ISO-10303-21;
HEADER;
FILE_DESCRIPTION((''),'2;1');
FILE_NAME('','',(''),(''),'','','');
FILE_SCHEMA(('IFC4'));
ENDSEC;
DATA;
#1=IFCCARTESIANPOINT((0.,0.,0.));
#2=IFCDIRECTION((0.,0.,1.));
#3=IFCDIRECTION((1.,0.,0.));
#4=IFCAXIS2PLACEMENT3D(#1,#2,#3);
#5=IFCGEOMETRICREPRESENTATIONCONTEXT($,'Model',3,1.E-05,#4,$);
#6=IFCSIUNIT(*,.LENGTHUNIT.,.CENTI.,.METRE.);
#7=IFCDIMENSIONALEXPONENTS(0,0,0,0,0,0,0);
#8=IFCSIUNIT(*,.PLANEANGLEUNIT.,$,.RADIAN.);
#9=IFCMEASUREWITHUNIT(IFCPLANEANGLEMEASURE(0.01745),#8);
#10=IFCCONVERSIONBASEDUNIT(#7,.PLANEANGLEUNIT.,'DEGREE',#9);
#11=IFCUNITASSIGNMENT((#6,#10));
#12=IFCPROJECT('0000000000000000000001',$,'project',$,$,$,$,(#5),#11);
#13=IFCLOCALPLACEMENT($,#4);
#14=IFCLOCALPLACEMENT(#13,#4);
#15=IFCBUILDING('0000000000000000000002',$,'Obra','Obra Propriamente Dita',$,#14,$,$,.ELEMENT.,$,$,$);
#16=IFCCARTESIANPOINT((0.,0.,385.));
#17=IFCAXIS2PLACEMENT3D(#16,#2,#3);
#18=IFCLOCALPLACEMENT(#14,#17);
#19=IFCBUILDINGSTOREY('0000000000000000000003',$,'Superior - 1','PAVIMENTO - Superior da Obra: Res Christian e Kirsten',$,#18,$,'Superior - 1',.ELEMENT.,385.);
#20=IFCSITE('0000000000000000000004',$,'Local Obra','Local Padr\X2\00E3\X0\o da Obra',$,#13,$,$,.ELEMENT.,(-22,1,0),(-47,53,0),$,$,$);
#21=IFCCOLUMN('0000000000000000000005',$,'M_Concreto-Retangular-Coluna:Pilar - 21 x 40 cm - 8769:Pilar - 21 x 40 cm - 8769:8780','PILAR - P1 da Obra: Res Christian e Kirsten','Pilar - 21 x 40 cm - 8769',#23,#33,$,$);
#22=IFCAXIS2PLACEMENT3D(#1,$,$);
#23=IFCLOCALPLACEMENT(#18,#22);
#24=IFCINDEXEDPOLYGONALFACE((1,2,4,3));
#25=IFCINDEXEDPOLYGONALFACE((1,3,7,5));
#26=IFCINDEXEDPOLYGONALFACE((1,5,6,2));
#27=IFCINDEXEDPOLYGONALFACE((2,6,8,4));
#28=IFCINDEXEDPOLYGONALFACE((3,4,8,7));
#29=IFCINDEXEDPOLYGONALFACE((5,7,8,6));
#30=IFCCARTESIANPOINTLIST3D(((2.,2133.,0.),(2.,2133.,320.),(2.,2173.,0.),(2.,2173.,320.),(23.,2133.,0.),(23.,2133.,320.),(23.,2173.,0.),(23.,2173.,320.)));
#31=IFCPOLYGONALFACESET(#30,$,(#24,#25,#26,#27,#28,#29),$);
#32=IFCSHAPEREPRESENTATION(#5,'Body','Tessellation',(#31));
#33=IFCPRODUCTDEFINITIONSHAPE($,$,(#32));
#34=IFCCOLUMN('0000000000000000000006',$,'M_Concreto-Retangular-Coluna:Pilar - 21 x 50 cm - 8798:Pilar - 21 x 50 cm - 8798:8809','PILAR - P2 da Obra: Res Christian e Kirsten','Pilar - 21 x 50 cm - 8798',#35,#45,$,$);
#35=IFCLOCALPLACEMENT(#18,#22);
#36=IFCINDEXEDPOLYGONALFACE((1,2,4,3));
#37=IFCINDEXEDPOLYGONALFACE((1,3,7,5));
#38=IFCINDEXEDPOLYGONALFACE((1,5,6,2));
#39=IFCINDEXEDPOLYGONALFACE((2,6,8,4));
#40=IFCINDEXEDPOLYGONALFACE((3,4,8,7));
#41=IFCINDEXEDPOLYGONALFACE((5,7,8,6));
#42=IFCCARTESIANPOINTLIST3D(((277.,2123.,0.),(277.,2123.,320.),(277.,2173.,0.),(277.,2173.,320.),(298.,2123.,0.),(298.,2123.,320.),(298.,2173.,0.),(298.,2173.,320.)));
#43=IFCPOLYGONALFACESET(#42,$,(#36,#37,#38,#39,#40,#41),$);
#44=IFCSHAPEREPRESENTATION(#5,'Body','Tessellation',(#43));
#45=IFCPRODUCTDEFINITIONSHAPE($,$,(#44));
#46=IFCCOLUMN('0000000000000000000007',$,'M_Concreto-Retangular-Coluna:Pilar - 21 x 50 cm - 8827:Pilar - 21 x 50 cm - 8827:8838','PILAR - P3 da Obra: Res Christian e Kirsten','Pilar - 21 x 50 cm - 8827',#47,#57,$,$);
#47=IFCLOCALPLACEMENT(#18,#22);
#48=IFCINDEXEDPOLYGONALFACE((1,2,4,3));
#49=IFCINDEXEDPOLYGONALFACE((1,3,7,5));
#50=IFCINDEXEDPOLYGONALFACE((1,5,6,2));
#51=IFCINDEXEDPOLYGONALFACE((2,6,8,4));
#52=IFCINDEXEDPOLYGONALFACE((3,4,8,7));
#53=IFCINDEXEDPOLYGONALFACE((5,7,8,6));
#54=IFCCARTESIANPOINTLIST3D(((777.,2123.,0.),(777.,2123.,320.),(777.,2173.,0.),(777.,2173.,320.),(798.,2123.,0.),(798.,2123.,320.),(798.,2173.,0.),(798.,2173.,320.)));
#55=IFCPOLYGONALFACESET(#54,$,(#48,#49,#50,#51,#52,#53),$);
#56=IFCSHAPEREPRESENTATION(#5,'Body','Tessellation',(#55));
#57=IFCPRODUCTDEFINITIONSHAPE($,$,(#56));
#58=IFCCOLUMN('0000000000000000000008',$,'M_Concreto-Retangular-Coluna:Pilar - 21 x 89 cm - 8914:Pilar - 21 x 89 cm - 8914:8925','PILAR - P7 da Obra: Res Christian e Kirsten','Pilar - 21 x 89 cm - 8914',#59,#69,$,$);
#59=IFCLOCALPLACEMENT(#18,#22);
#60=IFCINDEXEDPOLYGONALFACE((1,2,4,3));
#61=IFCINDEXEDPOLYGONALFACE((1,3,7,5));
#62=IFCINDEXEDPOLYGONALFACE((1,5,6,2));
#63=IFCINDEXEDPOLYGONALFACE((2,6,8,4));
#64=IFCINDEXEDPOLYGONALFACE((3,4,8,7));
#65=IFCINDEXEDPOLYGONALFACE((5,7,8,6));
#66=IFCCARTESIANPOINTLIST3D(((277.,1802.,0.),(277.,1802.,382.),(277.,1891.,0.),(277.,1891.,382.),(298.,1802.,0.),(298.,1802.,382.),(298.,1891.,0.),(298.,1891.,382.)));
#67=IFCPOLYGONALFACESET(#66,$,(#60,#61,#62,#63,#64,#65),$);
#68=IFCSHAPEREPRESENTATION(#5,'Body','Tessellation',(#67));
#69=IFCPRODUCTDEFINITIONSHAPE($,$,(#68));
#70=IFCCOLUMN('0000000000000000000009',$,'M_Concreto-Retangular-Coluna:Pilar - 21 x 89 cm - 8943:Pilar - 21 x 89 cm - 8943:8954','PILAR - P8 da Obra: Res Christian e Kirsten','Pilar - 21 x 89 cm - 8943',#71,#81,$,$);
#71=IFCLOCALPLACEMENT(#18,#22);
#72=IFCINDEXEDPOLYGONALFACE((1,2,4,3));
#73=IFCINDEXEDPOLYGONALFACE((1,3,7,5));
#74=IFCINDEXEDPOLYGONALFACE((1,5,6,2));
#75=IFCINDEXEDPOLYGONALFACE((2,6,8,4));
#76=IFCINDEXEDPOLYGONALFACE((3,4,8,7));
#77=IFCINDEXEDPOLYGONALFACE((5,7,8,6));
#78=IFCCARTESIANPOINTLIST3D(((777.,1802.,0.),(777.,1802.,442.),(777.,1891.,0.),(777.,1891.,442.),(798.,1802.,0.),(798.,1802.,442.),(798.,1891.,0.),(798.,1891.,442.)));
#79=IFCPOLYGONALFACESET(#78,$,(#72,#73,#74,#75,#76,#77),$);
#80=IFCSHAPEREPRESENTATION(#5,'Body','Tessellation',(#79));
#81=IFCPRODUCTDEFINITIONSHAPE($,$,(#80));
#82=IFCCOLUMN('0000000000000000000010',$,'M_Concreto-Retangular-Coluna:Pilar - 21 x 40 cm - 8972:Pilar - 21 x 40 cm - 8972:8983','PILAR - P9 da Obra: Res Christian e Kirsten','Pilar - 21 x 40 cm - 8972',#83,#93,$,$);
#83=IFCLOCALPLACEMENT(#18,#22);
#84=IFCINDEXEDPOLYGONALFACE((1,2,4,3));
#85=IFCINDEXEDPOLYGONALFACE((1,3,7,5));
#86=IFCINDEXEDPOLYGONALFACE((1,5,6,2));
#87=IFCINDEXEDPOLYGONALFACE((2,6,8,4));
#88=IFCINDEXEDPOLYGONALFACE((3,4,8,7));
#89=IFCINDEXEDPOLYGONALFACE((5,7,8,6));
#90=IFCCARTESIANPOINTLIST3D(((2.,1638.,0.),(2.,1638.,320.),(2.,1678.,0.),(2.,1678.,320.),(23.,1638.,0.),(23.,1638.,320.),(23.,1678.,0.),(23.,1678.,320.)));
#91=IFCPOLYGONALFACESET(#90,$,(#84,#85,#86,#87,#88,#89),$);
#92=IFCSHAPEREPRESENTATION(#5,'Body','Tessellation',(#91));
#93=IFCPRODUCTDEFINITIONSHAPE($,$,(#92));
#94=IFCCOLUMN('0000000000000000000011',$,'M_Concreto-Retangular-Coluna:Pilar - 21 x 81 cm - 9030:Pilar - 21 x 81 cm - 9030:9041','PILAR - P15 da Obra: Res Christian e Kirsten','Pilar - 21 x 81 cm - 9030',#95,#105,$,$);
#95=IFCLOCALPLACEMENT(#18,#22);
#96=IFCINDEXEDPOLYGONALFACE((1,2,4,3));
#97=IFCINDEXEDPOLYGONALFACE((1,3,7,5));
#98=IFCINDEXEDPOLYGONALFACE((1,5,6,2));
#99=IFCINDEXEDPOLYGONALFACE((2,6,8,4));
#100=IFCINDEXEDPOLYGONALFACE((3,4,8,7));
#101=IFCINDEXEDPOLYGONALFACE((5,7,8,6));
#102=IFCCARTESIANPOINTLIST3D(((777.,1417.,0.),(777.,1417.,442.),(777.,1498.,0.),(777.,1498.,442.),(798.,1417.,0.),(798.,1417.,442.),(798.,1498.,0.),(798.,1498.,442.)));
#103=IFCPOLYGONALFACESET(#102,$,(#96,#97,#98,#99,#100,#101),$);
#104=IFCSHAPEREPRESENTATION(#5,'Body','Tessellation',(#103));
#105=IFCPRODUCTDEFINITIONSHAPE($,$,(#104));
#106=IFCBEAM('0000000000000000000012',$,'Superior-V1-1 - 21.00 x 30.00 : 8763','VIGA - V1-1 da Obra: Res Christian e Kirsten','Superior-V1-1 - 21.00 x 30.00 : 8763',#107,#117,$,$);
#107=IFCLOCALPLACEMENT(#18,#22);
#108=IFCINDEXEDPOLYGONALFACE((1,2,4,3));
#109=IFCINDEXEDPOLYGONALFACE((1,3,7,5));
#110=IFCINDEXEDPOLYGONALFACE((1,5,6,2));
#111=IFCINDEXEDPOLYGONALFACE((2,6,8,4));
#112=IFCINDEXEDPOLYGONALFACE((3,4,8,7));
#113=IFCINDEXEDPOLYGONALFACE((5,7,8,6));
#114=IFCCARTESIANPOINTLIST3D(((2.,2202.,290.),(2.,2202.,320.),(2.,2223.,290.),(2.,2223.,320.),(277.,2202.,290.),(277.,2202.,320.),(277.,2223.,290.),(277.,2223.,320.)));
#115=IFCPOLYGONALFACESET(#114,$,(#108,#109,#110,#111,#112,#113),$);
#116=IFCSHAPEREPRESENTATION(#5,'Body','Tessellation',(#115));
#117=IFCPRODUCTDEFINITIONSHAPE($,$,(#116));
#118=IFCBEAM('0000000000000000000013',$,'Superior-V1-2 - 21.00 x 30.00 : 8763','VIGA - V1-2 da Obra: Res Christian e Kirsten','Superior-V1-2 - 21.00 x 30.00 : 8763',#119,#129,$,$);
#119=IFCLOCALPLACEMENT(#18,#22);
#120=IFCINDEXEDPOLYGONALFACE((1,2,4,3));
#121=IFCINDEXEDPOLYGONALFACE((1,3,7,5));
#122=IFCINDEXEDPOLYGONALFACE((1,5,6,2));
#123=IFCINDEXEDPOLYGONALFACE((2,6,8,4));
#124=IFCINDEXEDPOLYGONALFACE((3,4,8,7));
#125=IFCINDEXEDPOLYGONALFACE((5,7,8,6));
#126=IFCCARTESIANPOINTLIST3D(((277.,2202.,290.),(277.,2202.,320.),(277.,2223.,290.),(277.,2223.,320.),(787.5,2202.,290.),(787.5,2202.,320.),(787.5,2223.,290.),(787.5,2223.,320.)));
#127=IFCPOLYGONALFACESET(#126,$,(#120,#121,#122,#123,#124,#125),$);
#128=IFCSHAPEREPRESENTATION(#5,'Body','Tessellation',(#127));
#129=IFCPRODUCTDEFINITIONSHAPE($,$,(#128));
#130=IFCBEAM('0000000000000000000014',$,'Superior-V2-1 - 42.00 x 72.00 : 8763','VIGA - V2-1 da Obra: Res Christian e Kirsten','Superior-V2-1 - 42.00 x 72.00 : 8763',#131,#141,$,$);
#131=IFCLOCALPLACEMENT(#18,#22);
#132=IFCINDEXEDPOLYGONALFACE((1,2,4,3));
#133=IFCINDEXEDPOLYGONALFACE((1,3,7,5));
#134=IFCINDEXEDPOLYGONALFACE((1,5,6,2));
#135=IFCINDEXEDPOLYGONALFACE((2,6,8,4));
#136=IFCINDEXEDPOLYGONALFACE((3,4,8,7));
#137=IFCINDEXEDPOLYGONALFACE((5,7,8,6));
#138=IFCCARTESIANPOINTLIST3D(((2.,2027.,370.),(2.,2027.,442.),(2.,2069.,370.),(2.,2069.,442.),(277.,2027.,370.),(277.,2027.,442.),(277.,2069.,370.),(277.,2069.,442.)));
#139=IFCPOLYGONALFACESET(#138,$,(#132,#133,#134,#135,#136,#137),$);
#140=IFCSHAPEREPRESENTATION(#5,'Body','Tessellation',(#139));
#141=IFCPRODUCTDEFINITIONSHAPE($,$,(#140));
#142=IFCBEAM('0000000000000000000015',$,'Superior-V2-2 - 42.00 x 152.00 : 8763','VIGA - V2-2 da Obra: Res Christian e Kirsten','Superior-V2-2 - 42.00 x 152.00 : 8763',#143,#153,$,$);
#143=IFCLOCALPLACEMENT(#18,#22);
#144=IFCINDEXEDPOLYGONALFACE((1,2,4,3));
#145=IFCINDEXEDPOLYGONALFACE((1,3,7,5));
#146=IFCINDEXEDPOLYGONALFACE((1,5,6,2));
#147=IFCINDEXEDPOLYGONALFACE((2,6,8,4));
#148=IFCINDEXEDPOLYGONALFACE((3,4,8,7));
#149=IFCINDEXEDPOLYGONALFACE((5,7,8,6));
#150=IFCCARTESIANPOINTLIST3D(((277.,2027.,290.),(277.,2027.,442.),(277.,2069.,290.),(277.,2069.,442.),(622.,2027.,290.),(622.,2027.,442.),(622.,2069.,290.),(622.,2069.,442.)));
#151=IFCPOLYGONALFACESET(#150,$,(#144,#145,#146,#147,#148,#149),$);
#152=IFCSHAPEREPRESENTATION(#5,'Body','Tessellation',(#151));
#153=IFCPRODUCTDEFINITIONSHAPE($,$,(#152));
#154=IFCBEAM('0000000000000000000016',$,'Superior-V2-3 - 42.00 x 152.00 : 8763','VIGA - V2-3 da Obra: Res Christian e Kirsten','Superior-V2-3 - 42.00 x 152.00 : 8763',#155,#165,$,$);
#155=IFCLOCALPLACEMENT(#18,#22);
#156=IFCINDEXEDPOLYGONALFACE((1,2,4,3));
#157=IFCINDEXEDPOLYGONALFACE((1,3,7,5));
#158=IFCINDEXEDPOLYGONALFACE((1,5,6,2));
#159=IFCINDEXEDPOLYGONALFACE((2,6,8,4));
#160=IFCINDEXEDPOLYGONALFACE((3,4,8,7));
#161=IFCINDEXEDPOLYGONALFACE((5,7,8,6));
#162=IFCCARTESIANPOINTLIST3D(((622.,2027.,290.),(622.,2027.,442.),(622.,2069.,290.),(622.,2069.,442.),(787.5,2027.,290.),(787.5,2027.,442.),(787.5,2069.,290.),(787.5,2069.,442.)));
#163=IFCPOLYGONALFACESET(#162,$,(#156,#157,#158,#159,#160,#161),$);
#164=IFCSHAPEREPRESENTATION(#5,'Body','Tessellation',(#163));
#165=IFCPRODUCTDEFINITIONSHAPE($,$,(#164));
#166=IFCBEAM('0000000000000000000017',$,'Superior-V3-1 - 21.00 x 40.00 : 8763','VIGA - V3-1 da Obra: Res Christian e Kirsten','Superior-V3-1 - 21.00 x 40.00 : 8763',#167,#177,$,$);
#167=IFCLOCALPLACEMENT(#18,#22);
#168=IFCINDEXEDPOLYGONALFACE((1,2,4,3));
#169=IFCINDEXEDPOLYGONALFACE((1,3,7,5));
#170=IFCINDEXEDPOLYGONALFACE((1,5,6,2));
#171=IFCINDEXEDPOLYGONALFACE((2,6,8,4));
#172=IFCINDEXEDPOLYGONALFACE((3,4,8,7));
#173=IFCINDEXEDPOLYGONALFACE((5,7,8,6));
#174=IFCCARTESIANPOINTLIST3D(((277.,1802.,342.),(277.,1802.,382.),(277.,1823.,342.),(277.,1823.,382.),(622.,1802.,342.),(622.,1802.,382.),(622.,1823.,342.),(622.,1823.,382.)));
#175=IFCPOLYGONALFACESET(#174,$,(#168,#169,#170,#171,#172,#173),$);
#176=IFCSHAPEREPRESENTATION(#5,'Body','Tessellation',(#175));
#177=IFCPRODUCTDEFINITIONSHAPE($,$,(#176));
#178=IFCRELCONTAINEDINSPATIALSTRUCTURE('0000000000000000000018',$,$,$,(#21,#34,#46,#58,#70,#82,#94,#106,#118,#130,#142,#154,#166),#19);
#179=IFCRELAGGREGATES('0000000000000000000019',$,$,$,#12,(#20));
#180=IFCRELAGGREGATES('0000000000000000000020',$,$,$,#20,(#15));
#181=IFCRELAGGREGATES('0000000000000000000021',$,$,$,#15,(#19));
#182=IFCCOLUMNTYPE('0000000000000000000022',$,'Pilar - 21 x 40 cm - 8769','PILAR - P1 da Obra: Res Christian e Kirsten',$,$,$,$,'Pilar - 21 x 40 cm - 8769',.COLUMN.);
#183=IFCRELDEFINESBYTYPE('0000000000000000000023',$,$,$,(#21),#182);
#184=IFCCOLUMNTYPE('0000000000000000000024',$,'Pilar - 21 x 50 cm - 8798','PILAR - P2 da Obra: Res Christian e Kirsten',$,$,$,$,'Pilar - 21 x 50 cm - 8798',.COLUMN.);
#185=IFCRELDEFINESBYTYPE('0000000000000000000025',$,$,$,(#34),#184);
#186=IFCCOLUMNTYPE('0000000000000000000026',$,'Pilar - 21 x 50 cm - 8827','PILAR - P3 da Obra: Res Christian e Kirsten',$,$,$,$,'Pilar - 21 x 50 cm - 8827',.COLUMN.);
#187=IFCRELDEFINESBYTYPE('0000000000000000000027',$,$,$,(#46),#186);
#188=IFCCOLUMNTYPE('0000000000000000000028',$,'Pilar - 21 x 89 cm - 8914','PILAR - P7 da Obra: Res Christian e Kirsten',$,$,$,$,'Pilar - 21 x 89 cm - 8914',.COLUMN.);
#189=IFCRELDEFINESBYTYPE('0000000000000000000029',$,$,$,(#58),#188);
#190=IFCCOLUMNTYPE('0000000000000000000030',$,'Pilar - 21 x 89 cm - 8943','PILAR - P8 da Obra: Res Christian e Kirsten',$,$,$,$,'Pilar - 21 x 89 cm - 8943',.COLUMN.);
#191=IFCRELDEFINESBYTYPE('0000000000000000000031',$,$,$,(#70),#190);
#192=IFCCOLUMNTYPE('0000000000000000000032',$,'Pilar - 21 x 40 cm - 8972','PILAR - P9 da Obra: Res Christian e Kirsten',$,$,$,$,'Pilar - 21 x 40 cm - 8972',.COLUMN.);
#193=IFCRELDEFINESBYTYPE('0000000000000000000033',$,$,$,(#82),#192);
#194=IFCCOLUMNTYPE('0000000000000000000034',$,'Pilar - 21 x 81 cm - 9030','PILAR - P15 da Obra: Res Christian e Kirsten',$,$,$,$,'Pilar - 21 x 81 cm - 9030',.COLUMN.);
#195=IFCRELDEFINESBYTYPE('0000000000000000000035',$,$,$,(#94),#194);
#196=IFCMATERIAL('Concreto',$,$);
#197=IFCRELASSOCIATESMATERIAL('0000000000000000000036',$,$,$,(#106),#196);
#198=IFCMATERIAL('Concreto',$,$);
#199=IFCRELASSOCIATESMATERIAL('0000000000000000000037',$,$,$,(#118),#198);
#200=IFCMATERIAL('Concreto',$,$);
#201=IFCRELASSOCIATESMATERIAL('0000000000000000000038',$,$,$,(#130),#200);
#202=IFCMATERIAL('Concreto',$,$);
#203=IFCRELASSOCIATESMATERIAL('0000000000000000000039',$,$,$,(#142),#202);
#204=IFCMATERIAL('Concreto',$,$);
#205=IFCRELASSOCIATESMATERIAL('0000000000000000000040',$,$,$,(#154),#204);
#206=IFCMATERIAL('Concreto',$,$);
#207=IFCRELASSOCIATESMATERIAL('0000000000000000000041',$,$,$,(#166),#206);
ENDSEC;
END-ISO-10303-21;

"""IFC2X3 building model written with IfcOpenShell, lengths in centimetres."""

from ifc_helpers import new_model, entity, si_unit, converted_unit, frame, origin, origin_with_axes, origin_2d_with_axis, place, context, project, spatial, polyline, rectangle, outline, extrude, source, transform, mapped, material, type_object, type_shapes, element, save


model = new_model("IFC2X3")

# Units and contexts
model_context = context("Model", 3, precision=1e-05, world=origin_with_axes())
ifc_project = project(units=[si_unit("LENGTHUNIT", "METRE", prefix="CENTI"), converted_unit("PLANEANGLEUNIT", "DEGREE", entity("IfcPlaneAngleMeasure", 0.01745), si_unit("PLANEANGLEUNIT", "RADIAN"), dimensions=[0, 0, 0, 0, 0, 0, 0])], contexts=[model_context])

# Site, building, storey
site_placement = place(None, origin_with_axes())
site = spatial("IfcSite", under=ifc_project, at=site_placement, Name="Local Obra", Description="Local Padrão da Obra", CompositionType="ELEMENT", RefLatitude=(-22, 1, 0), RefLongitude=(-47, 53, 0))
building_placement = place(site_placement, origin_with_axes())
building = spatial("IfcBuilding", under=site, at=building_placement, Name="Obra", Description="Obra Propriamente Dita", CompositionType="ELEMENT")
storey_placement = place(building_placement, frame((0.0, 0.0, 385.0), z_axis=(0.0, 0.0, 1.0), x_axis=(1.0, 0.0, 0.0)))
storey = spatial("IfcBuildingStorey", under=building, at=storey_placement, Name="Superior - 1", Description="PAVIMENTO - Superior da Obra: Res Christian e Kirsten", LongName="Superior - 1", CompositionType="ELEMENT", Elevation=385.0)

# Columns
column_type_1 = type_object("IfcColumnType", Name="Pilar - 21 x 40 cm - 8769", Description="PILAR - P1 da Obra: Res Christian e Kirsten", ElementType="Pilar - 21 x 40 cm - 8769", PredefinedType="COLUMN")
shared_shape_1 = source(origin(), model_context, "Body", "SweptSolid", [
    extrude(rectangle(XDim=21.0, YDim=40.0, at=origin_2d_with_axis()), origin(), (0.0, 0.0, 1.0), 320.0),
])
type_shapes(column_type_1, [shared_shape_1])
column_1_placement = place(storey_placement, frame((12.5, 2153.0, 0.0), z_axis=(0.0, 0.0, 1.0), x_axis=(1.0, 0.0, 0.0)))
element("IfcColumn", 1, at=column_1_placement, inside=storey, type_object=column_type_1, Name="M_Concreto-Retangular-Coluna:Pilar - 21 x 40 cm - 8769:Pilar - 21 x 40 cm - 8769:8780", Description="PILAR - P1 da Obra: Res Christian e Kirsten", ObjectType="Pilar - 21 x 40 cm - 8769", context=model_context, shape_type="MappedRepresentation", body=[
    mapped(shared_shape_1, transform((0.0, 0.0, 0.0), scale=1.0)),
])
column_type_2 = type_object("IfcColumnType", Name="Pilar - 21 x 50 cm - 8798", Description="PILAR - P2 da Obra: Res Christian e Kirsten", ElementType="Pilar - 21 x 50 cm - 8798", PredefinedType="COLUMN")
shared_shape_2 = source(origin(), model_context, "Body", "SweptSolid", [
    extrude(rectangle(XDim=21.0, YDim=50.0, at=origin_2d_with_axis()), origin(), (0.0, 0.0, 1.0), 320.0),
])
type_shapes(column_type_2, [shared_shape_2])
column_2_placement = place(storey_placement, frame((287.5, 2148.0, 0.0), z_axis=(0.0, 0.0, 1.0), x_axis=(1.0, 0.0, 0.0)))
element("IfcColumn", 2, at=column_2_placement, inside=storey, type_object=column_type_2, Name="M_Concreto-Retangular-Coluna:Pilar - 21 x 50 cm - 8798:Pilar - 21 x 50 cm - 8798:8809", Description="PILAR - P2 da Obra: Res Christian e Kirsten", ObjectType="Pilar - 21 x 50 cm - 8798", context=model_context, shape_type="MappedRepresentation", body=[
    mapped(shared_shape_2, transform((0.0, 0.0, 0.0), scale=1.0)),
])
column_type_3 = type_object("IfcColumnType", Name="Pilar - 21 x 50 cm - 8827", Description="PILAR - P3 da Obra: Res Christian e Kirsten", ElementType="Pilar - 21 x 50 cm - 8827", PredefinedType="COLUMN")
shared_shape_3 = source(origin(), model_context, "Body", "SweptSolid", [
    extrude(rectangle(XDim=21.0, YDim=50.0, at=origin_2d_with_axis()), origin(), (0.0, 0.0, 1.0), 320.0),
])
type_shapes(column_type_3, [shared_shape_3])
column_3_placement = place(storey_placement, frame((787.5, 2148.0, 0.0), z_axis=(0.0, 0.0, 1.0), x_axis=(1.0, 0.0, 0.0)))
element("IfcColumn", 3, at=column_3_placement, inside=storey, type_object=column_type_3, Name="M_Concreto-Retangular-Coluna:Pilar - 21 x 50 cm - 8827:Pilar - 21 x 50 cm - 8827:8838", Description="PILAR - P3 da Obra: Res Christian e Kirsten", ObjectType="Pilar - 21 x 50 cm - 8827", context=model_context, shape_type="MappedRepresentation", body=[
    mapped(shared_shape_3, transform((0.0, 0.0, 0.0), scale=1.0)),
])
column_type_4 = type_object("IfcColumnType", Name="Pilar - 21 x 89 cm - 8914", Description="PILAR - P7 da Obra: Res Christian e Kirsten", ElementType="Pilar - 21 x 89 cm - 8914", PredefinedType="COLUMN")
shared_shape_4 = source(origin(), model_context, "Body", "SweptSolid", [
    extrude(rectangle(XDim=21.0, YDim=89.0, at=origin_2d_with_axis()), origin(), (0.0, 0.0, 1.0), 382.0),
])
type_shapes(column_type_4, [shared_shape_4])
column_4_placement = place(storey_placement, frame((287.5, 1846.5, 0.0), z_axis=(0.0, 0.0, 1.0), x_axis=(1.0, 0.0, 0.0)))
element("IfcColumn", 4, at=column_4_placement, inside=storey, type_object=column_type_4, Name="M_Concreto-Retangular-Coluna:Pilar - 21 x 89 cm - 8914:Pilar - 21 x 89 cm - 8914:8925", Description="PILAR - P7 da Obra: Res Christian e Kirsten", ObjectType="Pilar - 21 x 89 cm - 8914", context=model_context, shape_type="MappedRepresentation", body=[
    mapped(shared_shape_4, transform((0.0, 0.0, 0.0), scale=1.0)),
])
column_type_5 = type_object("IfcColumnType", Name="Pilar - 21 x 89 cm - 8943", Description="PILAR - P8 da Obra: Res Christian e Kirsten", ElementType="Pilar - 21 x 89 cm - 8943", PredefinedType="COLUMN")
shared_shape_5 = source(origin(), model_context, "Body", "SweptSolid", [
    extrude(rectangle(XDim=21.0, YDim=89.0, at=origin_2d_with_axis()), origin(), (0.0, 0.0, 1.0), 442.0),
])
type_shapes(column_type_5, [shared_shape_5])
column_5_placement = place(storey_placement, frame((787.5, 1846.5, 0.0), z_axis=(0.0, 0.0, 1.0), x_axis=(1.0, 0.0, 0.0)))
element("IfcColumn", 5, at=column_5_placement, inside=storey, type_object=column_type_5, Name="M_Concreto-Retangular-Coluna:Pilar - 21 x 89 cm - 8943:Pilar - 21 x 89 cm - 8943:8954", Description="PILAR - P8 da Obra: Res Christian e Kirsten", ObjectType="Pilar - 21 x 89 cm - 8943", context=model_context, shape_type="MappedRepresentation", body=[
    mapped(shared_shape_5, transform((0.0, 0.0, 0.0), scale=1.0)),
])
column_type_6 = type_object("IfcColumnType", Name="Pilar - 21 x 40 cm - 8972", Description="PILAR - P9 da Obra: Res Christian e Kirsten", ElementType="Pilar - 21 x 40 cm - 8972", PredefinedType="COLUMN")
shared_shape_6 = source(origin(), model_context, "Body", "SweptSolid", [
    extrude(rectangle(XDim=21.0, YDim=40.0, at=origin_2d_with_axis()), origin(), (0.0, 0.0, 1.0), 320.0),
])
type_shapes(column_type_6, [shared_shape_6])
column_6_placement = place(storey_placement, frame((12.5, 1658.0, 0.0), z_axis=(0.0, 0.0, 1.0), x_axis=(1.0, 0.0, 0.0)))
element("IfcColumn", 6, at=column_6_placement, inside=storey, type_object=column_type_6, Name="M_Concreto-Retangular-Coluna:Pilar - 21 x 40 cm - 8972:Pilar - 21 x 40 cm - 8972:8983", Description="PILAR - P9 da Obra: Res Christian e Kirsten", ObjectType="Pilar - 21 x 40 cm - 8972", context=model_context, shape_type="MappedRepresentation", body=[
    mapped(shared_shape_6, transform((0.0, 0.0, 0.0), scale=1.0)),
])
column_type_7 = type_object("IfcColumnType", Name="Pilar - 21 x 81 cm - 9030", Description="PILAR - P15 da Obra: Res Christian e Kirsten", ElementType="Pilar - 21 x 81 cm - 9030", PredefinedType="COLUMN")
shared_shape_7 = source(origin(), model_context, "Body", "SweptSolid", [
    extrude(rectangle(XDim=21.0, YDim=81.0, at=origin_2d_with_axis()), origin(), (0.0, 0.0, 1.0), 442.0),
])
type_shapes(column_type_7, [shared_shape_7])
column_7_placement = place(storey_placement, frame((787.5, 1457.5, 0.0), z_axis=(0.0, 0.0, 1.0), x_axis=(1.0, 0.0, 0.0)))
element("IfcColumn", 7, at=column_7_placement, inside=storey, type_object=column_type_7, Name="M_Concreto-Retangular-Coluna:Pilar - 21 x 81 cm - 9030:Pilar - 21 x 81 cm - 9030:9041", Description="PILAR - P15 da Obra: Res Christian e Kirsten", ObjectType="Pilar - 21 x 81 cm - 9030", context=model_context, shape_type="MappedRepresentation", body=[
    mapped(shared_shape_7, transform((0.0, 0.0, 0.0), scale=1.0)),
])

# Beams
ifc_material_1 = material(Name="Concreto")
beam_1_placement = place(storey_placement, frame((2.0, 2223.0, 320.0), z_axis=(1.0, 0.0, 0.0), x_axis=(0.0, -1.0, 0.0)))
element("IfcBeam", 8, at=beam_1_placement, inside=storey, material=ifc_material_1, Name="Superior-V1-1 - 21.00 x 30.00 : 8763", Description="VIGA - V1-1 da Obra: Res Christian e Kirsten", ObjectType="Superior-V1-1 - 21.00 x 30.00 : 8763", context=model_context, shape_type="SweptSolid", body=[
    extrude(outline(polyline([(0.0, 0.0), (21.0, 0.0), (21.0, 30.0), (0.0, 30.0), (0.0, 0.0)])), origin_with_axes(), (0.0, 0.0, 1.0), 275.0),
])
ifc_material_2 = material(Name="Concreto")
beam_2_placement = place(storey_placement, frame((277.0, 2223.0, 320.0), z_axis=(1.0, 0.0, 0.0), x_axis=(0.0, -1.0, 0.0)))
element("IfcBeam", 9, at=beam_2_placement, inside=storey, material=ifc_material_2, Name="Superior-V1-2 - 21.00 x 30.00 : 8763", Description="VIGA - V1-2 da Obra: Res Christian e Kirsten", ObjectType="Superior-V1-2 - 21.00 x 30.00 : 8763", context=model_context, shape_type="SweptSolid", body=[
    extrude(outline(polyline([(0.0, 0.0), (21.0, 0.0), (21.0, 30.0), (0.0, 30.0), (0.0, 0.0)])), origin_with_axes(), (0.0, 0.0, 1.0), 510.5),
])
ifc_material_3 = material(Name="Concreto")
beam_3_placement = place(storey_placement, frame((2.0, 2048.0, 442.0), z_axis=(1.0, 0.0, 0.0), x_axis=(0.0, -1.0, 0.0)))
element("IfcBeam", 10, at=beam_3_placement, inside=storey, material=ifc_material_3, Name="Superior-V2-1 - 42.00 x 72.00 : 8763", Description="VIGA - V2-1 da Obra: Res Christian e Kirsten", ObjectType="Superior-V2-1 - 42.00 x 72.00 : 8763", context=model_context, shape_type="SweptSolid", body=[
    extrude(outline(polyline([(-21.0, 0.0), (21.0, 0.0), (21.0, 72.0), (-21.0, 72.0), (-21.0, 0.0)])), origin_with_axes(), (0.0, 0.0, 1.0), 275.0),
])
ifc_material_4 = material(Name="Concreto")
beam_4_placement = place(storey_placement, frame((277.0, 2048.0, 442.0), z_axis=(1.0, 0.0, 0.0), x_axis=(0.0, -1.0, 0.0)))
element("IfcBeam", 11, at=beam_4_placement, inside=storey, material=ifc_material_4, Name="Superior-V2-2 - 42.00 x 152.00 : 8763", Description="VIGA - V2-2 da Obra: Res Christian e Kirsten", ObjectType="Superior-V2-2 - 42.00 x 152.00 : 8763", context=model_context, shape_type="SweptSolid", body=[
    extrude(outline(polyline([(-21.0, 0.0), (21.0, 0.0), (21.0, 152.0), (-21.0, 152.0), (-21.0, 0.0)])), origin_with_axes(), (0.0, 0.0, 1.0), 345.0),
])
ifc_material_5 = material(Name="Concreto")
beam_5_placement = place(storey_placement, frame((622.0, 2048.0, 442.0), z_axis=(1.0, 0.0, 0.0), x_axis=(0.0, -1.0, 0.0)))
element("IfcBeam", 12, at=beam_5_placement, inside=storey, material=ifc_material_5, Name="Superior-V2-3 - 42.00 x 152.00 : 8763", Description="VIGA - V2-3 da Obra: Res Christian e Kirsten", ObjectType="Superior-V2-3 - 42.00 x 152.00 : 8763", context=model_context, shape_type="SweptSolid", body=[
    extrude(outline(polyline([(-21.0, 0.0), (21.0, 0.0), (21.0, 152.0), (-21.0, 152.0), (-21.0, 0.0)])), origin_with_axes(), (0.0, 0.0, 1.0), 165.5),
])
ifc_material_6 = material(Name="Concreto")
beam_6_placement = place(storey_placement, frame((277.0, 1802.0, 382.0), z_axis=(1.0, 0.0, 0.0), x_axis=(0.0, -1.0, 0.0)))
element("IfcBeam", 13, at=beam_6_placement, inside=storey, material=ifc_material_6, Name="Superior-V3-1 - 21.00 x 40.00 : 8763", Description="VIGA - V3-1 da Obra: Res Christian e Kirsten", ObjectType="Superior-V3-1 - 21.00 x 40.00 : 8763", context=model_context, shape_type="SweptSolid", body=[
    extrude(outline(polyline([(-21.0, 0.0), (0.0, 0.0), (0.0, 40.0), (-21.0, 40.0), (-21.0, 0.0)])), origin_with_axes(), (0.0, 0.0, 1.0), 345.0),
])

save(model, "model.ifc")
